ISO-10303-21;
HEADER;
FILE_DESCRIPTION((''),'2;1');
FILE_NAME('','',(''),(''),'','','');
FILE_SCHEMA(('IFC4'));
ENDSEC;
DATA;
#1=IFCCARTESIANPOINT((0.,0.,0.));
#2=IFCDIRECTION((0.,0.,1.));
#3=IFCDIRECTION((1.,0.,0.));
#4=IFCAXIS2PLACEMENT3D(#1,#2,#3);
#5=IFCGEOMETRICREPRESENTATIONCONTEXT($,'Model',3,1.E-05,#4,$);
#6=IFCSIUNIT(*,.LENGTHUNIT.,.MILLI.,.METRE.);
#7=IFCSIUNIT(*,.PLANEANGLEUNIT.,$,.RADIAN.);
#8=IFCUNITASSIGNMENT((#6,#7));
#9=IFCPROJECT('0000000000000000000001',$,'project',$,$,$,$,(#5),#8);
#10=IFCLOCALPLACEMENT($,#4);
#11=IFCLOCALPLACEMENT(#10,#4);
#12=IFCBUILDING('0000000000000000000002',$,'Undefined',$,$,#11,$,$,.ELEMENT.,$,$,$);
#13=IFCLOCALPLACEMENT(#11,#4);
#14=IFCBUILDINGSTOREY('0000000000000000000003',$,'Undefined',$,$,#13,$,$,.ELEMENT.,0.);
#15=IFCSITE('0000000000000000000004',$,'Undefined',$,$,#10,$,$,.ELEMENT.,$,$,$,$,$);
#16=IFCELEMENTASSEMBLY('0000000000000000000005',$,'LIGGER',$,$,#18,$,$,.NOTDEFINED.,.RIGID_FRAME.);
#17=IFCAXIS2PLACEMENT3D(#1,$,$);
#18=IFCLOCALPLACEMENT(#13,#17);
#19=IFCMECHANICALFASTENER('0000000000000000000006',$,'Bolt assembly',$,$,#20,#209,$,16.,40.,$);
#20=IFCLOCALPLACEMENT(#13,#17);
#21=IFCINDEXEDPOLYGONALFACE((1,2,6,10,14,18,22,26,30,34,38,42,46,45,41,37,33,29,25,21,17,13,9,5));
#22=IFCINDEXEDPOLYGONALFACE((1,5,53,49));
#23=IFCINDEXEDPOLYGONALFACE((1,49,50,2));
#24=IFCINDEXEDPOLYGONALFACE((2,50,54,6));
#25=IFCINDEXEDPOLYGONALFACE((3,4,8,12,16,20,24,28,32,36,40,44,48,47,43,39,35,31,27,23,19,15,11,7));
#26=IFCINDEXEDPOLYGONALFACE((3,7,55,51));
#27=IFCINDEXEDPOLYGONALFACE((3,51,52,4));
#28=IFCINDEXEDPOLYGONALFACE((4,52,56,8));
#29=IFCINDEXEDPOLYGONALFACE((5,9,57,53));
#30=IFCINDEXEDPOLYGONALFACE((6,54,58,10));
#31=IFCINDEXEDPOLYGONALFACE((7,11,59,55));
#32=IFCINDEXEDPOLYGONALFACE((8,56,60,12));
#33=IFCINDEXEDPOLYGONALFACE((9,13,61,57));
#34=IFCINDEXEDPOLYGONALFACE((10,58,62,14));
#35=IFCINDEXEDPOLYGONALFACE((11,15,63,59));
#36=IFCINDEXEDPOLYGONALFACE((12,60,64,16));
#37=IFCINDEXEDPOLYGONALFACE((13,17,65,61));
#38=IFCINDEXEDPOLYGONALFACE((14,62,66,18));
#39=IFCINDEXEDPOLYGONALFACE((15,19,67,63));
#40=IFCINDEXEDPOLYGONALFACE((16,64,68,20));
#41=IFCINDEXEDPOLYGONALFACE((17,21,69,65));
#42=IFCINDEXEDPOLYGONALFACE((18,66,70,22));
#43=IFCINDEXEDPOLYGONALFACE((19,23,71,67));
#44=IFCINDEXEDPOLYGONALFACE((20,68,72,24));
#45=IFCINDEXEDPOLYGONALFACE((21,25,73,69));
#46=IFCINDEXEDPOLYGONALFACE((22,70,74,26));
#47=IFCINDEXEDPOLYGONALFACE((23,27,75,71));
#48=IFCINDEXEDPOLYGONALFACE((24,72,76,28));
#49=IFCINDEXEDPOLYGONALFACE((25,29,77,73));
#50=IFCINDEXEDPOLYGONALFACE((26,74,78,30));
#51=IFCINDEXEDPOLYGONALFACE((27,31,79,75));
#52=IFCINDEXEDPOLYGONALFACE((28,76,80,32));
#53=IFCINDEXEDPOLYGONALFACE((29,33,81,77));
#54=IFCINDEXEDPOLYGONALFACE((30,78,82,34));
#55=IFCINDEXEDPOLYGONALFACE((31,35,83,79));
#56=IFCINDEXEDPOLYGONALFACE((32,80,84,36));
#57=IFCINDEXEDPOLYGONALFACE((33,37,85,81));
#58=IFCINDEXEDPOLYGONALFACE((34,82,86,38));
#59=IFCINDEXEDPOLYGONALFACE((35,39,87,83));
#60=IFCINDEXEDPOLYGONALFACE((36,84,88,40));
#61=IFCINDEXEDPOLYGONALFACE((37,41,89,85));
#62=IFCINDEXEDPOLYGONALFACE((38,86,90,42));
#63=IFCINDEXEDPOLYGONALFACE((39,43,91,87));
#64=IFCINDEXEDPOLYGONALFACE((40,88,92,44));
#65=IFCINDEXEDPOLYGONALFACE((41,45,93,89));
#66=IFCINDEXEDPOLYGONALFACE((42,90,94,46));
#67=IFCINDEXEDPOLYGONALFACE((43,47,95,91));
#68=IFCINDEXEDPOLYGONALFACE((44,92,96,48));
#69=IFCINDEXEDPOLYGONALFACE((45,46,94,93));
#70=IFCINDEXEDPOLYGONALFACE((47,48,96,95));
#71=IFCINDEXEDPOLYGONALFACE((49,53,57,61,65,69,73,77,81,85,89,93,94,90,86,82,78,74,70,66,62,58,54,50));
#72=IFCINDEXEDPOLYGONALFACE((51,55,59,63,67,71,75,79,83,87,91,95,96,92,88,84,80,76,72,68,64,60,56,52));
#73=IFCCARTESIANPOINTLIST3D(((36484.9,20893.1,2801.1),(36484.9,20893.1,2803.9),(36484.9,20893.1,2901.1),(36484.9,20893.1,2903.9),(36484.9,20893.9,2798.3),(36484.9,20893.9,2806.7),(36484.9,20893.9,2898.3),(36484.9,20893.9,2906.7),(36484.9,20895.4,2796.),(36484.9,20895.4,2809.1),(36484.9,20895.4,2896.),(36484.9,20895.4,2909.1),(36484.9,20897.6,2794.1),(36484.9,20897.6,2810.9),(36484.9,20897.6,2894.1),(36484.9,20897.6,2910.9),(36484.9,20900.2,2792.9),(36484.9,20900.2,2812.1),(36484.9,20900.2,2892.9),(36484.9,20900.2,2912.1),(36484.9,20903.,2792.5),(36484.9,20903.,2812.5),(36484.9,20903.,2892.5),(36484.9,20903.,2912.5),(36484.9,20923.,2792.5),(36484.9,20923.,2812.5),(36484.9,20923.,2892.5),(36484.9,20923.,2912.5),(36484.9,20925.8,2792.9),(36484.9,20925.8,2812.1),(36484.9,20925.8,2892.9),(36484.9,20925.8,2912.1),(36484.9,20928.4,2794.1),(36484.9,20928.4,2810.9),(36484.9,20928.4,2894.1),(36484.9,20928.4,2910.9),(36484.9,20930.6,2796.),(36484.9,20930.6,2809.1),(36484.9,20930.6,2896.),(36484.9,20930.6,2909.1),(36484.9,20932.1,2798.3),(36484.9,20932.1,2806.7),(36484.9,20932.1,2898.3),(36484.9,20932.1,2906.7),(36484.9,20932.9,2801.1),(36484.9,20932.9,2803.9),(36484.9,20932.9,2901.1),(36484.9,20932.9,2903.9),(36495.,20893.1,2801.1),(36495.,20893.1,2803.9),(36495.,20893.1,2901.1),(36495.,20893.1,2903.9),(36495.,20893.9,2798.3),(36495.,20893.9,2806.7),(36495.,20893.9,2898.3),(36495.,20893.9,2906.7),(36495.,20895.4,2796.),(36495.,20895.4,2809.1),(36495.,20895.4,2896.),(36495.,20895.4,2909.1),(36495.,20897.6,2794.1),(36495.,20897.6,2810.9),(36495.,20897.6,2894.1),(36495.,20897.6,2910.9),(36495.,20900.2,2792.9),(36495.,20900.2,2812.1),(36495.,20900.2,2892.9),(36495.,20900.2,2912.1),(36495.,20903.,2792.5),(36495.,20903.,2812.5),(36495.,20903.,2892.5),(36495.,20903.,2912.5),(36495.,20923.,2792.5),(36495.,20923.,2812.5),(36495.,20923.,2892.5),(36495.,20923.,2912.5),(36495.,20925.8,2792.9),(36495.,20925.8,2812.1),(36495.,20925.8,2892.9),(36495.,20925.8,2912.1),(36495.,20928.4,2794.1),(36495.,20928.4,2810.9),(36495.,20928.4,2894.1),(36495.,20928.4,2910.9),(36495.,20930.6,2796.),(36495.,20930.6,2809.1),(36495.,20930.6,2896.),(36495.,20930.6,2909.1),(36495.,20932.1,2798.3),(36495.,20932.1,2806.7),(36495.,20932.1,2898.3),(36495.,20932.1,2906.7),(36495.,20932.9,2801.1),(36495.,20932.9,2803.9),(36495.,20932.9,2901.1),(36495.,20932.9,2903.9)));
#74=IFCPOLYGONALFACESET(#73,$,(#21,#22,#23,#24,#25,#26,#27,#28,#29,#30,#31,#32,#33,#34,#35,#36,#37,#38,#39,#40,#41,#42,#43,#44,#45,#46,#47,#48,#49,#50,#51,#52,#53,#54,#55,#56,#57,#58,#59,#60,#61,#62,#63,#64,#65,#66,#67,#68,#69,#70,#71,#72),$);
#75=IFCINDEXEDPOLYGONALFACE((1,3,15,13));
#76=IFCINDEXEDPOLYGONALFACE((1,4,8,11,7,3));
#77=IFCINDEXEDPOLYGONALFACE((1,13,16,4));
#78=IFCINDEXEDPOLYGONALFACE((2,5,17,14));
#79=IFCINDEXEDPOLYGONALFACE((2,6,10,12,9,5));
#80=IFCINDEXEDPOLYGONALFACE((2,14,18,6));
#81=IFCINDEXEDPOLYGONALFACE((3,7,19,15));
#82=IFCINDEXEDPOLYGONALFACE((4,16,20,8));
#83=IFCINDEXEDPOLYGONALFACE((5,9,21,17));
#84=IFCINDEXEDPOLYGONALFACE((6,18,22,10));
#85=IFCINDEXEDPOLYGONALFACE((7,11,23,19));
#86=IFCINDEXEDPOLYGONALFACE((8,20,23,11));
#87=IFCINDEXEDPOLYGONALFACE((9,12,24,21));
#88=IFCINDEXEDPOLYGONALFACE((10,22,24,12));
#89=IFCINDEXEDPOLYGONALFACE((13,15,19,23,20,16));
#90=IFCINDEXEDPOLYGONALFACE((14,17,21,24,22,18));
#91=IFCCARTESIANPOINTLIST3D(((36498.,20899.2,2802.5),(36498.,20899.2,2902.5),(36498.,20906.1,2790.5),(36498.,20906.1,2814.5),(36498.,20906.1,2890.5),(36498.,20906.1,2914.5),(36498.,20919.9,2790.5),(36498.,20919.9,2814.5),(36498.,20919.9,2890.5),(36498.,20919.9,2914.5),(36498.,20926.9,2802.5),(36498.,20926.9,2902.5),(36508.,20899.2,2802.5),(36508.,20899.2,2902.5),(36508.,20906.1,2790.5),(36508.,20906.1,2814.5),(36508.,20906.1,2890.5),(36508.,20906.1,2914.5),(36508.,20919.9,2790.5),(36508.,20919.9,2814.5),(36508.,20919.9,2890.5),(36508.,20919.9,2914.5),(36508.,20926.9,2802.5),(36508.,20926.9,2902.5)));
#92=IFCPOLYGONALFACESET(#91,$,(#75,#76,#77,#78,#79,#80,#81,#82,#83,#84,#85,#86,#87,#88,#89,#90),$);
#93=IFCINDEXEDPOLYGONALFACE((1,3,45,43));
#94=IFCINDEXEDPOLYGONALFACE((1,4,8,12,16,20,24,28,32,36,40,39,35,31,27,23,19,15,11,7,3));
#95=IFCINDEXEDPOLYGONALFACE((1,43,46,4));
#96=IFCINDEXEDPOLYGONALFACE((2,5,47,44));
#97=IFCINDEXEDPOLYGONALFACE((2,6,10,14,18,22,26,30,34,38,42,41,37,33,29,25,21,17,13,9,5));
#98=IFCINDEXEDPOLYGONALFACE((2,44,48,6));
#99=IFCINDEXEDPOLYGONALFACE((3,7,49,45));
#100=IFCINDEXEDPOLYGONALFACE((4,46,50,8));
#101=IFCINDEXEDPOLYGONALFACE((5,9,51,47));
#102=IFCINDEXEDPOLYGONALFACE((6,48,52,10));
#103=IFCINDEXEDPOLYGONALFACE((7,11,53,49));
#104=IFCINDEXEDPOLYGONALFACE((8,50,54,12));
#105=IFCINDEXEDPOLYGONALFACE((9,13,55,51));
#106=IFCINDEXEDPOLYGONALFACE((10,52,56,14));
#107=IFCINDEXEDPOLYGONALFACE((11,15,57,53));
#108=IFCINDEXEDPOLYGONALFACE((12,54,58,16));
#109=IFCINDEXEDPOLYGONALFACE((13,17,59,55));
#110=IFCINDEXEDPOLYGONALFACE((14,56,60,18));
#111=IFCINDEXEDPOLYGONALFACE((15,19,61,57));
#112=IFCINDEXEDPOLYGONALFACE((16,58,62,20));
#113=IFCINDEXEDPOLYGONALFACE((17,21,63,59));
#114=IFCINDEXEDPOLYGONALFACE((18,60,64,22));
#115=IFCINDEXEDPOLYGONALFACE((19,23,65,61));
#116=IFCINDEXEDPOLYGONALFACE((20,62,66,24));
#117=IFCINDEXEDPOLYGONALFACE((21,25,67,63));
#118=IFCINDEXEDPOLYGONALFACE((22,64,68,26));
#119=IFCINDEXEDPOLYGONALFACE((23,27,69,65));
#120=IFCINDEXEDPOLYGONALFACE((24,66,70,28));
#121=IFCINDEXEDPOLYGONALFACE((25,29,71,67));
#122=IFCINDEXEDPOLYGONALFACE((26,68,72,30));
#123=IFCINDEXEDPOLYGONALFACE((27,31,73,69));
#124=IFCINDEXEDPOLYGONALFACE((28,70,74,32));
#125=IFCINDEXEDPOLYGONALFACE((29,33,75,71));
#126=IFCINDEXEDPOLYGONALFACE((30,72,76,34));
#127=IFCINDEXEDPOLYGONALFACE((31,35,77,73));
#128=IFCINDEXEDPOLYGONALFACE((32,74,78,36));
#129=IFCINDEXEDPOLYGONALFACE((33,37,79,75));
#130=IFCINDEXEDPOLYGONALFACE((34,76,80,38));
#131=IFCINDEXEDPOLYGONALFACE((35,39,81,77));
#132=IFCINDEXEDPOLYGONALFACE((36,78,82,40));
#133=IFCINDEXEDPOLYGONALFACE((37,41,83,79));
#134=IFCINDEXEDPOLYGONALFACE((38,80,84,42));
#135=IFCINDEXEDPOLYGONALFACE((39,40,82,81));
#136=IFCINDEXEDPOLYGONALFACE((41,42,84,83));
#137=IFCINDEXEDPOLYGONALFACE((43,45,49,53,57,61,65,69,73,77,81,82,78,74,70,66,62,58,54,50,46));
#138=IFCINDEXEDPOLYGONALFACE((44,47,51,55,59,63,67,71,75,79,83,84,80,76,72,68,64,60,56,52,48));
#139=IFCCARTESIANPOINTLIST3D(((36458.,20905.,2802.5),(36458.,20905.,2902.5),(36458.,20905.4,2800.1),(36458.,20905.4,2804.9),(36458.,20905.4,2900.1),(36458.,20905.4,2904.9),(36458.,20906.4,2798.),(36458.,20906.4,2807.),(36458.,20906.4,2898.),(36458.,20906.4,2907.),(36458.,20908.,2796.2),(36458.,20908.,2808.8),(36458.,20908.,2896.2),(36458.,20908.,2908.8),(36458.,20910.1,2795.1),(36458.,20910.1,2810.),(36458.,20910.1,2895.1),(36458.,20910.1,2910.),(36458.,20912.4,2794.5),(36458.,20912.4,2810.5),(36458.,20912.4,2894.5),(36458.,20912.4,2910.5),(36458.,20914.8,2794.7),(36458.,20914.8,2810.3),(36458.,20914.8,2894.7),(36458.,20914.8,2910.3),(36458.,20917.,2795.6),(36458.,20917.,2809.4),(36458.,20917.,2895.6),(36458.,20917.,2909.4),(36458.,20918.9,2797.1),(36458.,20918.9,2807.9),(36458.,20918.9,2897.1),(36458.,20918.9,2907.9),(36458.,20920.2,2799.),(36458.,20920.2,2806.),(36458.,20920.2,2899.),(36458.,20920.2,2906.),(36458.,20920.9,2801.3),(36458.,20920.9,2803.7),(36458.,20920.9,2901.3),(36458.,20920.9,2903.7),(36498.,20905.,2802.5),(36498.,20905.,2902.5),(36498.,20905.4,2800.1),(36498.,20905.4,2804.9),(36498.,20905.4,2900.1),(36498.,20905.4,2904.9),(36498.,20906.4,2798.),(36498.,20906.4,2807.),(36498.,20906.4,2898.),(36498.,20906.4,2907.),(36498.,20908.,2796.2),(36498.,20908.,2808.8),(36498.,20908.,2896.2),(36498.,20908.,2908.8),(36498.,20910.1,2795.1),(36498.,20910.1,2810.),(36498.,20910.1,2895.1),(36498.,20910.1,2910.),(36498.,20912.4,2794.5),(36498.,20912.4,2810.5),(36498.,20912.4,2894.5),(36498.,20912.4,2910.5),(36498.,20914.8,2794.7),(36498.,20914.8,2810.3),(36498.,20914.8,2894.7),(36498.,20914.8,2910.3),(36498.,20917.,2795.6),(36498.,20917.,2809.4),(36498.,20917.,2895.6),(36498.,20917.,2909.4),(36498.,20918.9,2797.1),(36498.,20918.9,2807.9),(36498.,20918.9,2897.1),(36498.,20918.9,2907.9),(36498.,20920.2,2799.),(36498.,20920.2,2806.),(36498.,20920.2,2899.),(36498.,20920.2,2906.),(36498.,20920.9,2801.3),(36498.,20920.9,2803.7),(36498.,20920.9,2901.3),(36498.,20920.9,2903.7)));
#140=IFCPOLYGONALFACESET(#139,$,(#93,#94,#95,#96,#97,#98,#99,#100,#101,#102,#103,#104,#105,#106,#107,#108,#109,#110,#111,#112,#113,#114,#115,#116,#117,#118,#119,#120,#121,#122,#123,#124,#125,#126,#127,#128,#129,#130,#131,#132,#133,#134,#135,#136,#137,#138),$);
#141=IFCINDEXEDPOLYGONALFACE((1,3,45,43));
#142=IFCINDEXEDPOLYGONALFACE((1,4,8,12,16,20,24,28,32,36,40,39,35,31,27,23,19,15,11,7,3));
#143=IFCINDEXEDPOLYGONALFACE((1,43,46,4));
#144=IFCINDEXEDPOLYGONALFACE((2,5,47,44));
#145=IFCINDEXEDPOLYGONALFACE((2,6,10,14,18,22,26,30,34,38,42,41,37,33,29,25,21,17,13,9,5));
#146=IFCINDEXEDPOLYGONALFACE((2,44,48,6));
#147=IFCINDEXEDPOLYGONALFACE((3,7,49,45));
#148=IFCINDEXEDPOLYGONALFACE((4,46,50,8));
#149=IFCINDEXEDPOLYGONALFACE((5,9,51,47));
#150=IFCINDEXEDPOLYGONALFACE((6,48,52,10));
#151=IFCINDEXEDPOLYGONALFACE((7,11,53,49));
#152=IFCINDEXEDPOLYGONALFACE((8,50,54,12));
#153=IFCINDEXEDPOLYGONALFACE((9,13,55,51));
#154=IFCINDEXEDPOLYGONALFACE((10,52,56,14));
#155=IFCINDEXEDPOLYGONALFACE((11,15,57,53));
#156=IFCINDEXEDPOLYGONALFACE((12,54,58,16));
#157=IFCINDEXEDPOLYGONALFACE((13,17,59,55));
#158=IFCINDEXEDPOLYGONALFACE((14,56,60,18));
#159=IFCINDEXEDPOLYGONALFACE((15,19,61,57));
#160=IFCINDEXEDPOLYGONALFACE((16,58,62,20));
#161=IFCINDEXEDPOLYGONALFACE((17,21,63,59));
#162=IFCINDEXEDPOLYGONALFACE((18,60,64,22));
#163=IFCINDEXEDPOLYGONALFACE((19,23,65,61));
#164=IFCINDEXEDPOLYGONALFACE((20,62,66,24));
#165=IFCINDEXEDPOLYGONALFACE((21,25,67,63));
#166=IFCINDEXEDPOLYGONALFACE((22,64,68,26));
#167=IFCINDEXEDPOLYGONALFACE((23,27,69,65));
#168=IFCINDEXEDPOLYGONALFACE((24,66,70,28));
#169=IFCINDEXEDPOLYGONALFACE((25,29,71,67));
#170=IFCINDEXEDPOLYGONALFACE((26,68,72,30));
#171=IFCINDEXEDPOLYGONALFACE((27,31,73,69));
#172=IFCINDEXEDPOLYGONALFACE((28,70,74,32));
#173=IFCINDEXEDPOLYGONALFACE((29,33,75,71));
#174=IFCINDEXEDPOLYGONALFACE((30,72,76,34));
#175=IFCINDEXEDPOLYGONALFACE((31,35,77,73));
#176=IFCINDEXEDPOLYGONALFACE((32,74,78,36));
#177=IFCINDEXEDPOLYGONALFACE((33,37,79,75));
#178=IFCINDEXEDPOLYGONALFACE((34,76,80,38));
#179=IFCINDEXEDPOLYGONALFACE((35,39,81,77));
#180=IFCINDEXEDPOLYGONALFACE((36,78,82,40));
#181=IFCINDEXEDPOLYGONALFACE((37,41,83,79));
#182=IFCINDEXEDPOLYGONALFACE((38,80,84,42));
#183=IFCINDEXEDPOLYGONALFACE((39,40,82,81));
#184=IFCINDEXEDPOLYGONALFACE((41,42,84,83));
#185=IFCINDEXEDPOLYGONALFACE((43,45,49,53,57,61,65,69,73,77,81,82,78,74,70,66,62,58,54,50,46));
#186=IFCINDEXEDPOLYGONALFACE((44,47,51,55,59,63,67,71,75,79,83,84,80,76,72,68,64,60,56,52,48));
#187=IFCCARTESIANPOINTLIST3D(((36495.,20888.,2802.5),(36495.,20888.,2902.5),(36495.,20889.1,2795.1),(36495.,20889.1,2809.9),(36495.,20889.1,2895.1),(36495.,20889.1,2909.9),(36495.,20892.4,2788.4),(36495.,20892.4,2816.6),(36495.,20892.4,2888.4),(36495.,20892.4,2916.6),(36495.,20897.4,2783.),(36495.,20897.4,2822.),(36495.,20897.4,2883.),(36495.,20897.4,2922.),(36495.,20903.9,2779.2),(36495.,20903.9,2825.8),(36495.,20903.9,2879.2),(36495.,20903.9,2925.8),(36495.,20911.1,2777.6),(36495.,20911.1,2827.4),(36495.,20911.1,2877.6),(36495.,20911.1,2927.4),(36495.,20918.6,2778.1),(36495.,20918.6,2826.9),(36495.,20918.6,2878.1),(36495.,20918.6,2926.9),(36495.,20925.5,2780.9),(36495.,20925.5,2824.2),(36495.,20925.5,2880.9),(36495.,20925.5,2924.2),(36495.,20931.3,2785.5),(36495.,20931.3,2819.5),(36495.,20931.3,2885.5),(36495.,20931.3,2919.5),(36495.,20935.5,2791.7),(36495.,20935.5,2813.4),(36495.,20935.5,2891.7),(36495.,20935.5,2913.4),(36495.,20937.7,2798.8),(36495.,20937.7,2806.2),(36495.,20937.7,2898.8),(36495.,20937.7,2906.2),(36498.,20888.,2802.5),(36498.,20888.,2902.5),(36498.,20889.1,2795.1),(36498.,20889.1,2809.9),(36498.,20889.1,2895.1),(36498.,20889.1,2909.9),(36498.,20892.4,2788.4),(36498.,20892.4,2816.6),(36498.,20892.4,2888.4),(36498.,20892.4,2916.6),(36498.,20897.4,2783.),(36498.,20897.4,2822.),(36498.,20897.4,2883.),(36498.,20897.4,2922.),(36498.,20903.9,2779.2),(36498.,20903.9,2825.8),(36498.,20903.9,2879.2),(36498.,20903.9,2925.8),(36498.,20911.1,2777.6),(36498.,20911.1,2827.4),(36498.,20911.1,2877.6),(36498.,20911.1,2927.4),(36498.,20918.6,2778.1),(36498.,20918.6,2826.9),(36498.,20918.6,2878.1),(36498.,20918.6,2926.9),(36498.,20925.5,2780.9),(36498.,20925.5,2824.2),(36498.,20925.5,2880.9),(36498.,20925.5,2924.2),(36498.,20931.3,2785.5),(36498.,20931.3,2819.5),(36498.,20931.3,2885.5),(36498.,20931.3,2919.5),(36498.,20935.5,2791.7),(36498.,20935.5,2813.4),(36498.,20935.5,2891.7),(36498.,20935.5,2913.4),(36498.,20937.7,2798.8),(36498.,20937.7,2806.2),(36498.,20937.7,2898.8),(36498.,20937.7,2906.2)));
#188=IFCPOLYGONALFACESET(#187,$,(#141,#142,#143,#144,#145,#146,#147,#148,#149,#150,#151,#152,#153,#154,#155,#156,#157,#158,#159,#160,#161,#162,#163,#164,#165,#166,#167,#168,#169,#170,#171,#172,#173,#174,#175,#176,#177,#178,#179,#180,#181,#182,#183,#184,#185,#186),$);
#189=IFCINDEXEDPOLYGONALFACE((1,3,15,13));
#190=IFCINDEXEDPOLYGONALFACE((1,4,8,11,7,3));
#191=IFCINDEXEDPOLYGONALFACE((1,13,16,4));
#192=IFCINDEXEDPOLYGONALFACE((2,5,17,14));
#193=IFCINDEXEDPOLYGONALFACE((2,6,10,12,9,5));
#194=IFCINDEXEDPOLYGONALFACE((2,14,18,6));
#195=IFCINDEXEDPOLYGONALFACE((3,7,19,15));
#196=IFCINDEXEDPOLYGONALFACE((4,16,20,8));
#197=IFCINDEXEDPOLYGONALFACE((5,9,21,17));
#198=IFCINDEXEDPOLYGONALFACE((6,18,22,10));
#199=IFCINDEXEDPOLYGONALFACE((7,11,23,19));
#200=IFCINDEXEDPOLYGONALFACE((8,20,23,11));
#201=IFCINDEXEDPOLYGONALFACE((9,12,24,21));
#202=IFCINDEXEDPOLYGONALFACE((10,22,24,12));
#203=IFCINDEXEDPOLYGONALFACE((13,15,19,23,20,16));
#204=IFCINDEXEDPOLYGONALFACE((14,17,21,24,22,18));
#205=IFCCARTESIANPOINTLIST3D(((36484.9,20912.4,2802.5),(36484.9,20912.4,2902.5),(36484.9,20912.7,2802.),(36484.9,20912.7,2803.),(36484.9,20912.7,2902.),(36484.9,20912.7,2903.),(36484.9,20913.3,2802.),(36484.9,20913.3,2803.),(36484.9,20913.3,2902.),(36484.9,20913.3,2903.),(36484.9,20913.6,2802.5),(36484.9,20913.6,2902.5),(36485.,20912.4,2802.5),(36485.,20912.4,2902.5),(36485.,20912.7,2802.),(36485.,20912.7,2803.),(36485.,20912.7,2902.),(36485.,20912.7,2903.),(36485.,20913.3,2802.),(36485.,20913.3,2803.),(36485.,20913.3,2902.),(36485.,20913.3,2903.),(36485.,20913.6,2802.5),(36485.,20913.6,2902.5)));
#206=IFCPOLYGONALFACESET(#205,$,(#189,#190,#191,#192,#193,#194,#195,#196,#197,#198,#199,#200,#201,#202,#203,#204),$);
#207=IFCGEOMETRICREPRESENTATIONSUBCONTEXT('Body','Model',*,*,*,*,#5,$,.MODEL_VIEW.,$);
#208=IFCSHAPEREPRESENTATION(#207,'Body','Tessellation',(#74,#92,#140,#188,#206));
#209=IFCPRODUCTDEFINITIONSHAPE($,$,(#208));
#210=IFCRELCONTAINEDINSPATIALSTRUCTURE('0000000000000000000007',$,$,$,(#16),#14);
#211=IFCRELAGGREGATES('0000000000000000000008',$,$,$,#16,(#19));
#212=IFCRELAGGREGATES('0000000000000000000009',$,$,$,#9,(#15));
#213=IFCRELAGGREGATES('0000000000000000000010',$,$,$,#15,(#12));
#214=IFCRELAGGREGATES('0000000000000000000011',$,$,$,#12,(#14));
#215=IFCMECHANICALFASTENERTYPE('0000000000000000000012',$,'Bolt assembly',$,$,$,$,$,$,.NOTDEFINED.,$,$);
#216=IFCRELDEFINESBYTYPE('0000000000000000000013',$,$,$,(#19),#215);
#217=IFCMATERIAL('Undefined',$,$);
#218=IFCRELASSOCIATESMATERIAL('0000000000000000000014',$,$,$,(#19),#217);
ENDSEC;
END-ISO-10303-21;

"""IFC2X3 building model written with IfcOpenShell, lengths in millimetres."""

from ifc_helpers import new_model, si_unit, frame, frame_2d, origin_with_axes, origin_2d_with_axis, place, context, subcontext, project, spatial, polyline, circle_curve, parameter, trimmed, segment, composite_curve, circle, outline, extrude, source, transform, mapped, material, type_object, element, aggregate, save


model = new_model("IFC2X3")

# Units and contexts
model_context = context("Model", 3, precision=1e-05, world=origin_with_axes())
body_context = subcontext(model_context, "Body", "Model", "MODEL_VIEW")
ifc_project = project(units=[si_unit("LENGTHUNIT", "METRE", prefix="MILLI"), si_unit("PLANEANGLEUNIT", "RADIAN")], contexts=[model_context])

# Site, building, storey
site_placement = place(None, origin_with_axes())
site = spatial("IfcSite", under=ifc_project, at=site_placement, Name="Undefined", CompositionType="ELEMENT")
building_placement = place(site_placement, origin_with_axes())
building = spatial("IfcBuilding", under=site, at=building_placement, Name="Undefined", CompositionType="ELEMENT")
storey_placement = place(building_placement, origin_with_axes())
storey = spatial("IfcBuildingStorey", under=building, at=storey_placement, Name="Undefined", CompositionType="ELEMENT", Elevation=0.0)

# Element assembly
assembly_1_placement = place(storey_placement, origin_with_axes())
assembly_1 = element("IfcElementAssembly", 1, at=assembly_1_placement, inside=storey, Name="LIGGER", AssemblyPlace="NOTDEFINED", PredefinedType="RIGID_FRAME")

# Shared definitions
ifc_material_1 = material(Name="Undefined")
mechanical_fastener_type = type_object("IfcMechanicalFastenerType", Name="Bolt assembly")

# Mechanical fastener
shared_shape_1 = source(origin_with_axes(), body_context, "Body", "SweptSolid", [
    extrude(outline(composite_curve([segment(polyline([(-10.0, 10.0), (10.0, 10.0)]), True, "CONTINUOUS"), segment(trimmed(circle_curve(frame_2d((10.0, 0.0), x_axis=(0.0, 1.0)), 10.0), [parameter(0.0)], [parameter(3.141593)], False, "PARAMETER"), True, "CONTINUOUS"), segment(polyline([(10.0, -10.0), (-10.0, -10.0)]), True, "CONTINUOUS"), segment(trimmed(circle_curve(frame_2d((-10.0, 0.0), x_axis=(0.0, -1.0)), 10.0), [parameter(0.0)], [parameter(3.141593)], False, "PARAMETER"), True, "DISCONTINUOUS")], self_intersect=False)), frame((0.0, 30.0, 0.0), z_axis=(0.0, 1.0, 0.0), x_axis=(1.0, 0.0, 0.0)), (0.0, 0.0, 1.0), 10.1),
    extrude(outline(polyline([(13.9, 0.0), (6.9, 12.0), (-6.9, 12.0), (-13.9, 0.0), (-6.9, -12.0), (6.9, -12.0), (13.9, 0.0)])), frame((0.0, 17.0, 0.0), z_axis=(0.0, 1.0, 0.0), x_axis=(1.0, 0.0, 0.0)), (0.0, 0.0, 1.0), 10.0),
    extrude(circle(Radius=8.0, at=origin_2d_with_axis()), frame((0.0, 27.0, 0.0), z_axis=(0.0, 1.0, 0.0), x_axis=(1.0, 0.0, 0.0)), (0.0, 0.0, 1.0), 40.0),
    extrude(circle(Radius=25.0, at=origin_2d_with_axis()), frame((0.0, 27.0, 0.0), z_axis=(0.0, 1.0, 0.0), x_axis=(1.0, 0.0, 0.0)), (0.0, 0.0, 1.0), 3.0),
    extrude(outline(polyline([(0.6, 0.0), (0.3, 0.5), (-0.3, 0.5), (-0.6, 0.0), (-0.3, -0.5), (0.3, -0.5), (0.6, 0.0)])), frame((0.0, 40.0, 0.0), z_axis=(0.0, 1.0, 0.0), x_axis=(1.0, 0.0, 0.0)), (0.0, 0.0, 1.0), 0.1),
])
mechanical_fastener_1_placement = place(assembly_1_placement, frame((36525.0, 20913.0, 2852.5), z_axis=(0.0, 0.000002, -1.0), x_axis=(0.0, -1.0, -0.000002)))
mechanical_fastener_1 = element("IfcMechanicalFastener", 2, at=mechanical_fastener_1_placement, type_object=mechanical_fastener_type, material=ifc_material_1, Name="Bolt assembly", NominalDiameter=16.0, NominalLength=40.0, context=body_context, shape_type="MappedRepresentation", body=[
    mapped(shared_shape_1, transform((0.0, 0.0, -50.0))),
    mapped(shared_shape_1, transform((0.0, 0.0, 50.0))),
])
aggregate(assembly_1, [mechanical_fastener_1])

save(model, "model.ifc")
